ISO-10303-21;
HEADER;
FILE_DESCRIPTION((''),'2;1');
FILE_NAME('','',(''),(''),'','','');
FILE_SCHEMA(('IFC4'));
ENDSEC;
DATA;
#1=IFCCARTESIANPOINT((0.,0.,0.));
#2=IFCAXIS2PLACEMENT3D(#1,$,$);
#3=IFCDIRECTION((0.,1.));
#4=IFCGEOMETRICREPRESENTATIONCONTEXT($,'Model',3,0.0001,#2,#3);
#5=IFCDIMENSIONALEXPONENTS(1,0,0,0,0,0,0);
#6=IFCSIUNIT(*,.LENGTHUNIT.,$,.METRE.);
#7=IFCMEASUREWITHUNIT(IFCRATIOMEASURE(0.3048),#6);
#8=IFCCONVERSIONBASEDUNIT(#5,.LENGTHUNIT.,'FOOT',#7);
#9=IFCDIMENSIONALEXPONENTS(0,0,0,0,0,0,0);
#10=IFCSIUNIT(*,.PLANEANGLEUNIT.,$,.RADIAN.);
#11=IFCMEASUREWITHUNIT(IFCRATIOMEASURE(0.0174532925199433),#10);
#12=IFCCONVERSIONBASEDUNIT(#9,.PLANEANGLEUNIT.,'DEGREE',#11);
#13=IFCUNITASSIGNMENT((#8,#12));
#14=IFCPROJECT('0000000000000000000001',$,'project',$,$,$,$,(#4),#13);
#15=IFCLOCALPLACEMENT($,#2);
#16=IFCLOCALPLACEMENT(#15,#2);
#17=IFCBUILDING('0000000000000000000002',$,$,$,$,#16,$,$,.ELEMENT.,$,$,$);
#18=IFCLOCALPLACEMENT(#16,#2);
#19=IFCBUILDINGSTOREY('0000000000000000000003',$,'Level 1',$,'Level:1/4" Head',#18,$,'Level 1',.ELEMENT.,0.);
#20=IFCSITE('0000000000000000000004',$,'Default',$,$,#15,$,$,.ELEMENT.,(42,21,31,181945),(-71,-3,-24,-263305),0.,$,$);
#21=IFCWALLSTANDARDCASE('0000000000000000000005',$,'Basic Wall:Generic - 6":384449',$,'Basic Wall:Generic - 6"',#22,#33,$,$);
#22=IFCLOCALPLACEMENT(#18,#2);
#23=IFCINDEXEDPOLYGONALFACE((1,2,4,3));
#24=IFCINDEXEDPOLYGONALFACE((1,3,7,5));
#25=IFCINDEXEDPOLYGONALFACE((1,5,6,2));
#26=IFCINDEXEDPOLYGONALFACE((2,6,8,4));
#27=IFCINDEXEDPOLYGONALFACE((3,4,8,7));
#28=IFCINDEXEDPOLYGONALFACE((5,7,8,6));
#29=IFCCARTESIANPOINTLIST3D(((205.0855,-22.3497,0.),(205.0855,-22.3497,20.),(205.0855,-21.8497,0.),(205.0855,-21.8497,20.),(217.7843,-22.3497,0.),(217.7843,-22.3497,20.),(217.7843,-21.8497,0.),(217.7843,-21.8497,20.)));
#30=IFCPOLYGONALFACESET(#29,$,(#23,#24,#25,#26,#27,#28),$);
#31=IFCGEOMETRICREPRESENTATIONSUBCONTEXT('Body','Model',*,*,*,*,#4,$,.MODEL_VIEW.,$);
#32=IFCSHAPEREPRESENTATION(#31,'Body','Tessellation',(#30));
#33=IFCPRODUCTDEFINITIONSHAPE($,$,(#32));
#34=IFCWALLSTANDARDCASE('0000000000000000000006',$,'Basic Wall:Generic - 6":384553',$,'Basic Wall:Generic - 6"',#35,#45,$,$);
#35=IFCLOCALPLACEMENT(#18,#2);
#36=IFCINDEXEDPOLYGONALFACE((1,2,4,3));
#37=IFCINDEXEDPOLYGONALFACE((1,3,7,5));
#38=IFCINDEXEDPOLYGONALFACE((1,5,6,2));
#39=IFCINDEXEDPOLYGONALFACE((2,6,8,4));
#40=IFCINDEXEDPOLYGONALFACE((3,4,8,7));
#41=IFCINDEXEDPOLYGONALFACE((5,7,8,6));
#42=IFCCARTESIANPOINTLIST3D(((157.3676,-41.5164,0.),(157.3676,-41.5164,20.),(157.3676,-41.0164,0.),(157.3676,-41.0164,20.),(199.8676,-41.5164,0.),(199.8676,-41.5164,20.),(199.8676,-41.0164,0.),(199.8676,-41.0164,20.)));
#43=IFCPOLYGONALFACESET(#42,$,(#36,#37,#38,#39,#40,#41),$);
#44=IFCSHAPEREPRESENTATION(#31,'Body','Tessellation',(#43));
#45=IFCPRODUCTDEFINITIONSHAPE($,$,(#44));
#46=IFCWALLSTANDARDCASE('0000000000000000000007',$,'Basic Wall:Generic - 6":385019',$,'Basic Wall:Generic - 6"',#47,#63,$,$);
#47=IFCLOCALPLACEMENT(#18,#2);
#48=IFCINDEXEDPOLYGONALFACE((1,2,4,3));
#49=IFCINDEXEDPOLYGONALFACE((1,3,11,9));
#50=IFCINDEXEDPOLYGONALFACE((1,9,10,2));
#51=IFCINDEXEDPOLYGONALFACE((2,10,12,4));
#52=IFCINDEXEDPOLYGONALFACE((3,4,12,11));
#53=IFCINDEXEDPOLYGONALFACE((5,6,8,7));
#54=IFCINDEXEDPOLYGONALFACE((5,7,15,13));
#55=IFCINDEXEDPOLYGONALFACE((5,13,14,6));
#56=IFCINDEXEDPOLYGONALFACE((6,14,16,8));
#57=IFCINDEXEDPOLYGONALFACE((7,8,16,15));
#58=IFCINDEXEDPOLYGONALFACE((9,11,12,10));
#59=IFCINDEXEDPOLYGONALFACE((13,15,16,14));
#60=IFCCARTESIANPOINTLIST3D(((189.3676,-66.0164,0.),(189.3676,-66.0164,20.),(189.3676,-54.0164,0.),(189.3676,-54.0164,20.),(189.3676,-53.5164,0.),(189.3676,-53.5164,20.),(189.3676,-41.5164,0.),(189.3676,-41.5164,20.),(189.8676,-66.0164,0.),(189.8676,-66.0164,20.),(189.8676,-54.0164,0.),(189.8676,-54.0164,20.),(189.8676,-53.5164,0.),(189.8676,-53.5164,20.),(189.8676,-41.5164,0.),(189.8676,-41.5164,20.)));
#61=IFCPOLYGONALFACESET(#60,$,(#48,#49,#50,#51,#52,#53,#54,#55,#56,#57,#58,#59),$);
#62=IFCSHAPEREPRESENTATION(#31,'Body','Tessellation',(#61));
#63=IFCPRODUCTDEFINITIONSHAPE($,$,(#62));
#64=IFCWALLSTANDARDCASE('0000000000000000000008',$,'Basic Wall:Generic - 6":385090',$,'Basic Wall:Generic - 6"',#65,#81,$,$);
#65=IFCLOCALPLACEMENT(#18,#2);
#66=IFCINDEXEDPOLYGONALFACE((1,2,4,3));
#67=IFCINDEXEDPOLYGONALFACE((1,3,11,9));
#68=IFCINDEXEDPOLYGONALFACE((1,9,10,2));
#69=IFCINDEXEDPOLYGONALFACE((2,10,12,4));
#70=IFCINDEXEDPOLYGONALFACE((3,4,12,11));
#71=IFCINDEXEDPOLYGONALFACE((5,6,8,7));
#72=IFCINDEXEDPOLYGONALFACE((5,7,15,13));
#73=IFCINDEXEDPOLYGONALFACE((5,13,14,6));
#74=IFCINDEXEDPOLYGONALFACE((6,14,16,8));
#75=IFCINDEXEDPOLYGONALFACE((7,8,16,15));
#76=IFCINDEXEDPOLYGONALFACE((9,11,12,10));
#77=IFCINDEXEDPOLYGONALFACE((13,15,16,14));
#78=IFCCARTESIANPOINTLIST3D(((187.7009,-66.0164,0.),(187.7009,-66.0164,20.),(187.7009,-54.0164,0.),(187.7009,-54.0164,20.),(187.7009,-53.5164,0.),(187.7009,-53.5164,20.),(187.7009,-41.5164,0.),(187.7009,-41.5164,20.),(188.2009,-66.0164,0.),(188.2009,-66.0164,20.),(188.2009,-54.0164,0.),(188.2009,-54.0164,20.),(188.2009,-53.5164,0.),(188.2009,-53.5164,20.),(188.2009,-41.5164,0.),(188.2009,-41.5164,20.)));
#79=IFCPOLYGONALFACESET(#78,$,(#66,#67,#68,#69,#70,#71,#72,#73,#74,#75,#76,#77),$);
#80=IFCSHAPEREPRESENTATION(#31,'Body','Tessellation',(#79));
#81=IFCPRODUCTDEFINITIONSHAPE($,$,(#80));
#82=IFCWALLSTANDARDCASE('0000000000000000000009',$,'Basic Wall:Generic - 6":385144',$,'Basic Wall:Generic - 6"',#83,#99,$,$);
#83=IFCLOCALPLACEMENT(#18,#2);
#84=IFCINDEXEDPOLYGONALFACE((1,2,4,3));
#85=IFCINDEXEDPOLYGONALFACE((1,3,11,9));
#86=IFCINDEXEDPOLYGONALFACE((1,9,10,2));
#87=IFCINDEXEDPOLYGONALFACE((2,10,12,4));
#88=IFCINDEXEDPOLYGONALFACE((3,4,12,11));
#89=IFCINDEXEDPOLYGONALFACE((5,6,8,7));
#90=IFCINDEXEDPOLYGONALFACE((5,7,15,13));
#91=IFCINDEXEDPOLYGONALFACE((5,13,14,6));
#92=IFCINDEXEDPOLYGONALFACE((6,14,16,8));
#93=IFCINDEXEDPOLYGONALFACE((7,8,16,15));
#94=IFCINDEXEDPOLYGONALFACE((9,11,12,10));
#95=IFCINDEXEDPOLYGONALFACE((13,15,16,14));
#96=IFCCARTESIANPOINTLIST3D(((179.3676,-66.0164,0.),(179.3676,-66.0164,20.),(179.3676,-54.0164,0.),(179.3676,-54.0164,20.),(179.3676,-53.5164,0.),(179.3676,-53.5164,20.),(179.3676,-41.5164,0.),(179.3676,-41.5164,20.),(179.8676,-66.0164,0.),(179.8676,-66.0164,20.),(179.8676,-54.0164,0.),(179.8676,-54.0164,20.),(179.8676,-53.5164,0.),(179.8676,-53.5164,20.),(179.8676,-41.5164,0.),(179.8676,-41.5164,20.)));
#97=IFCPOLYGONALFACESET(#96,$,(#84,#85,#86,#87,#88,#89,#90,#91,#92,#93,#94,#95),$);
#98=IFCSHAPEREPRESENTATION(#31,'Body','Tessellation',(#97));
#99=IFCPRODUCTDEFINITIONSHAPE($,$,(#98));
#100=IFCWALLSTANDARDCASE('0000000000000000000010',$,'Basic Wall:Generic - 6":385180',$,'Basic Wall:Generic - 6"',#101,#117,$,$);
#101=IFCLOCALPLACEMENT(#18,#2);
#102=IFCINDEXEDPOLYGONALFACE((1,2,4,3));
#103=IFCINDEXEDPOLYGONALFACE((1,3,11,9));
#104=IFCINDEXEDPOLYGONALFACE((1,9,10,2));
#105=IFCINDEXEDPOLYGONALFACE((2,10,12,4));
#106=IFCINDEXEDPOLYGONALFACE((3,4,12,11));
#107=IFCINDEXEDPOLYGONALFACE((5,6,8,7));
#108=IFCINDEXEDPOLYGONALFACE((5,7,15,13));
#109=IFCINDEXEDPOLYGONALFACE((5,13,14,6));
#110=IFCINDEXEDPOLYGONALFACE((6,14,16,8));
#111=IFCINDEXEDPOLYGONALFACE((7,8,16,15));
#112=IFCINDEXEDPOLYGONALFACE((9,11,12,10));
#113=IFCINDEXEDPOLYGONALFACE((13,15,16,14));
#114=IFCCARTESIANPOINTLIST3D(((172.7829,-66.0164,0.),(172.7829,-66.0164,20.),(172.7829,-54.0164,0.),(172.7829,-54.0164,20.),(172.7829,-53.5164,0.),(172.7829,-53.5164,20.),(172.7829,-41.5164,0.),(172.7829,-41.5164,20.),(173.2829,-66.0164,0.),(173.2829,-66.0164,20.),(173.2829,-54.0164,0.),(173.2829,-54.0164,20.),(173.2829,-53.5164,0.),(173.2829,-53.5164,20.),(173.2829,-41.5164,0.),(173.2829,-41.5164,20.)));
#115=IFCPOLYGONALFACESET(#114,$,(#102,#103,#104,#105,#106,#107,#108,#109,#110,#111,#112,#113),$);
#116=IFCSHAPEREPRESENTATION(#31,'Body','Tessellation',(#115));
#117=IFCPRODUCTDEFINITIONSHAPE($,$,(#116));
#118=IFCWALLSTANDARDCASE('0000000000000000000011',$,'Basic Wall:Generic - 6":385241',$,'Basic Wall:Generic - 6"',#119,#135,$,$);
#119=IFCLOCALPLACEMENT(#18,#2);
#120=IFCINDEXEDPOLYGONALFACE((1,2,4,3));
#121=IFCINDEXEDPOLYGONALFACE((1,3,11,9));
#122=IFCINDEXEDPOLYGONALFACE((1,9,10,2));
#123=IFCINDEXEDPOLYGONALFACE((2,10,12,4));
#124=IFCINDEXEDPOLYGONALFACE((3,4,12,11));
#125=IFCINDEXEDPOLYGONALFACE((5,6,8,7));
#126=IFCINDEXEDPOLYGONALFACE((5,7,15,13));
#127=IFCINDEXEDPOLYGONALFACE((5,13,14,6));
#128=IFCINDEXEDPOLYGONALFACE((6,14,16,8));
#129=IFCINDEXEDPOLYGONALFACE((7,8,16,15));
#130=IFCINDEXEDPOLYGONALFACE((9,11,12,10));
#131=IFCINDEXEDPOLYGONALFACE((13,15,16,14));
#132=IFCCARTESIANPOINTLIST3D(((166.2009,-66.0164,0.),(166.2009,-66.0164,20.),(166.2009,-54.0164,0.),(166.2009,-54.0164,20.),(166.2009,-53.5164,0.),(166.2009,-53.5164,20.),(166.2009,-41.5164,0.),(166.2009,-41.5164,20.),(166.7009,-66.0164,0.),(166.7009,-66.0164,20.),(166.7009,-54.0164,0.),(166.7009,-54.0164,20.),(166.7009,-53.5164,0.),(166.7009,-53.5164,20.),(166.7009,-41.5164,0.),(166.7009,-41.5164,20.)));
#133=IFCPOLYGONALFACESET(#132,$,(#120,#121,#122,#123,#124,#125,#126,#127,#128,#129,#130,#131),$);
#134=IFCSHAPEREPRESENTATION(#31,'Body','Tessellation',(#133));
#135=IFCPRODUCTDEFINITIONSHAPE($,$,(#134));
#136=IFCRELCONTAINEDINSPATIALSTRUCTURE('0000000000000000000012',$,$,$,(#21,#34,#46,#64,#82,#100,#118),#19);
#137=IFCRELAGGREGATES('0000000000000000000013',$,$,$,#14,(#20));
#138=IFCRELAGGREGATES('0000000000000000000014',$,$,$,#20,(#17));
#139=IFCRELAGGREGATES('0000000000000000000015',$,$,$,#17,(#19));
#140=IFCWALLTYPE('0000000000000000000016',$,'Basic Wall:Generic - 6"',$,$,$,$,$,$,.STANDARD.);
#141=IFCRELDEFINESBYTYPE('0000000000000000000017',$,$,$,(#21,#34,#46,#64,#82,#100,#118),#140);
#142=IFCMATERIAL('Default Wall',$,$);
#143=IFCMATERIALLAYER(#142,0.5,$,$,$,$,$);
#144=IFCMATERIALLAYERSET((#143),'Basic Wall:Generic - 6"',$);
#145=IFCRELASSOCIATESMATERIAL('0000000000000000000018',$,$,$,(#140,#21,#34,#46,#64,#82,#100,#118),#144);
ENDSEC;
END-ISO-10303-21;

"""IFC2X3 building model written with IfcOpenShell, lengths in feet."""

from ifc_helpers import new_model, entity, si_unit, converted_unit, direction, frame, frame_2d, origin, origin_2d_with_axis, place, context, subcontext, project, spatial, rectangle, extrude, material, layer, layer_set, layer_usage, type_object, element, save


model = new_model("IFC2X3")

# Units and contexts
model_context = context("Model", 3, precision=0.0001, world=origin(), true_north=direction((0.0, 1.0)))
body_context = subcontext(model_context, "Body", "Model", "MODEL_VIEW")
ifc_project = project(units=[converted_unit("LENGTHUNIT", "FOOT", entity("IfcRatioMeasure", 0.3048), si_unit("LENGTHUNIT", "METRE"), dimensions=[1, 0, 0, 0, 0, 0, 0]), converted_unit("PLANEANGLEUNIT", "DEGREE", entity("IfcRatioMeasure", 0.0174532925199433), si_unit("PLANEANGLEUNIT", "RADIAN"), dimensions=[0, 0, 0, 0, 0, 0, 0])], contexts=[model_context])

# Site, building, storey
site_placement = place(None, origin())
site = spatial("IfcSite", under=ifc_project, at=site_placement, Name="Default", CompositionType="ELEMENT", RefLatitude=(42, 21, 31, 181945), RefLongitude=(-71, -3, -24, -263305), RefElevation=0.0)
building_placement = place(site_placement, origin())
building = spatial("IfcBuilding", under=site, at=building_placement, CompositionType="ELEMENT")
storey_placement = place(building_placement, origin())
storey = spatial("IfcBuildingStorey", under=building, at=storey_placement, Name="Level 1", ObjectType="Level:1/4\" Head", LongName="Level 1", CompositionType="ELEMENT", Elevation=0.0)

# Walls
ifc_material = material(Name="Default Wall")
ifc_layer = layer(ifc_material, 0.5)
ifc_layer_set = layer_set([ifc_layer], Name="Basic Wall:Generic - 6\"")
wall_type = type_object("IfcWallType", Name="Basic Wall:Generic - 6\"", PredefinedType="STANDARD", material=ifc_layer_set)
ifc_layer_usage_1 = layer_usage(ifc_layer_set, "AXIS2", "NEGATIVE", 0.25)
wall_1_placement = place(storey_placement, frame((205.0855, -22.0997, 0.0)))
element("IfcWallStandardCase", 1, at=wall_1_placement, inside=storey, type_object=wall_type, material=ifc_layer_usage_1, Name="Basic Wall:Generic - 6\":384449", ObjectType="Basic Wall:Generic - 6\"", context=body_context, shape_type="SweptSolid", body=[
    extrude(rectangle(XDim=12.6987, YDim=0.5, at=frame_2d((6.3494, 0.0), x_axis=(-1.0, 0.0))), origin(), (0.0, 0.0, 1.0), 20.0),
])
ifc_layer_usage_2 = layer_usage(ifc_layer_set, "AXIS2", "NEGATIVE", 0.25)
wall_2_placement = place(storey_placement, frame((199.8676, -41.2664, 0.0), z_axis=(0.0, 0.0, 1.0), x_axis=(-1.0, 0.0, 0.0)))
element("IfcWallStandardCase", 2, at=wall_2_placement, inside=storey, type_object=wall_type, material=ifc_layer_usage_2, Name="Basic Wall:Generic - 6\":384553", ObjectType="Basic Wall:Generic - 6\"", context=body_context, shape_type="SweptSolid", body=[
    extrude(rectangle(XDim=42.5, YDim=0.5, at=frame_2d((21.25, 0.0), x_axis=(-1.0, 0.0))), origin(), (0.0, 0.0, 1.0), 20.0),
])

# Walls, openings
ifc_layer_usage_3 = layer_usage(ifc_layer_set, "AXIS2", "NEGATIVE", 0.25)
wall_3_placement = place(storey_placement, frame((189.6176, -41.5164, 0.0), z_axis=(0.0, 0.0, 1.0), x_axis=(0.0, -1.0, 0.0)))
wall_3 = element("IfcWallStandardCase", 3, at=wall_3_placement, inside=storey, type_object=wall_type, material=ifc_layer_usage_3, Name="Basic Wall:Generic - 6\":385019", ObjectType="Basic Wall:Generic - 6\"", context=body_context, shape_type="SweptSolid", body=[
    extrude(rectangle(XDim=24.5, YDim=0.5, at=frame_2d((12.25, 0.0), x_axis=(-1.0, 0.0))), origin(), (0.0, 0.0, 1.0), 20.0),
])
opening_1_placement = place(storey_placement, frame((189.6176, -41.5164, 0.0), z_axis=(0.0, 0.0, 1.0), x_axis=(0.0, -1.0, 0.0)))
element("IfcOpeningElement", 4, at=opening_1_placement, cuts=wall_3, ObjectType="Opening", context=body_context, shape_type="SweptSolid", body=[
    extrude(rectangle(XDim=20.0, YDim=0.5, at=origin_2d_with_axis()), frame((12.5, 0.0, 10.0), z_axis=(-1.0, 0.0, 0.0), x_axis=(0.0, 0.0, 1.0)), (0.0, 0.0, 1.0), 0.5),
])
ifc_layer_usage_4 = layer_usage(ifc_layer_set, "AXIS2", "NEGATIVE", 0.25)
wall_4_placement = place(storey_placement, frame((187.9509, -66.0164, 0.0), z_axis=(0.0, 0.0, 1.0), x_axis=(0.0, 1.0, 0.0)))
wall_4 = element("IfcWallStandardCase", 5, at=wall_4_placement, inside=storey, type_object=wall_type, material=ifc_layer_usage_4, Name="Basic Wall:Generic - 6\":385090", ObjectType="Basic Wall:Generic - 6\"", context=body_context, shape_type="SweptSolid", body=[
    extrude(rectangle(XDim=24.5, YDim=0.5, at=frame_2d((12.25, 0.0), x_axis=(-1.0, 0.0))), origin(), (0.0, 0.0, 1.0), 20.0),
])
opening_2_placement = place(storey_placement, frame((187.9509, -66.0164, 0.0), z_axis=(0.0, 0.0, 1.0), x_axis=(0.0, 1.0, 0.0)))
element("IfcOpeningElement", 6, at=opening_2_placement, cuts=wall_4, ObjectType="Opening", context=body_context, shape_type="SweptSolid", body=[
    extrude(rectangle(XDim=20.0, YDim=0.5, at=origin_2d_with_axis()), frame((12.0, 0.0, 10.0), z_axis=(1.0, 0.0, 0.0), x_axis=(0.0, 0.0, -1.0)), (0.0, 0.0, 1.0), 0.5),
])
ifc_layer_usage_5 = layer_usage(ifc_layer_set, "AXIS2", "NEGATIVE", 0.25)
wall_5_placement = place(storey_placement, frame((179.6176, -41.5164, 0.0), z_axis=(0.0, 0.0, 1.0), x_axis=(0.0, -1.0, 0.0)))
wall_5 = element("IfcWallStandardCase", 7, at=wall_5_placement, inside=storey, type_object=wall_type, material=ifc_layer_usage_5, Name="Basic Wall:Generic - 6\":385144", ObjectType="Basic Wall:Generic - 6\"", context=body_context, shape_type="SweptSolid", body=[
    extrude(rectangle(XDim=24.5, YDim=0.5, at=frame_2d((12.25, 0.0), x_axis=(-1.0, 0.0))), origin(), (0.0, 0.0, 1.0), 20.0),
])
opening_3_placement = place(storey_placement, frame((179.6176, -41.5164, 0.0), z_axis=(0.0, 0.0, 1.0), x_axis=(0.0, -1.0, 0.0)))
element("IfcOpeningElement", 8, at=opening_3_placement, cuts=wall_5, ObjectType="Opening", context=body_context, shape_type="SweptSolid", body=[
    extrude(rectangle(XDim=20.0, YDim=0.5, at=origin_2d_with_axis()), frame((12.5, 0.0, 10.0), z_axis=(-1.0, 0.0, 0.0), x_axis=(0.0, 0.0, 1.0)), (0.0, 0.0, 1.0), 0.5),
])
ifc_layer_usage_6 = layer_usage(ifc_layer_set, "AXIS2", "NEGATIVE", 0.25)
wall_6_placement = place(storey_placement, frame((173.0329, -66.0164, 0.0), z_axis=(0.0, 0.0, 1.0), x_axis=(0.0, 1.0, 0.0)))
wall_6 = element("IfcWallStandardCase", 9, at=wall_6_placement, inside=storey, type_object=wall_type, material=ifc_layer_usage_6, Name="Basic Wall:Generic - 6\":385180", ObjectType="Basic Wall:Generic - 6\"", context=body_context, shape_type="SweptSolid", body=[
    extrude(rectangle(XDim=24.5, YDim=0.5, at=frame_2d((12.25, 0.0), x_axis=(-1.0, 0.0))), origin(), (0.0, 0.0, 1.0), 20.0),
])
opening_4_placement = place(storey_placement, frame((173.0329, -66.0164, 0.0), z_axis=(0.0, 0.0, 1.0), x_axis=(0.0, 1.0, 0.0)))
element("IfcOpeningElement", 10, at=opening_4_placement, cuts=wall_6, ObjectType="Opening", context=body_context, shape_type="SweptSolid", body=[
    extrude(rectangle(XDim=20.0, YDim=0.5, at=origin_2d_with_axis()), frame((12.0, 0.0, 10.0), z_axis=(1.0, 0.0, 0.0), x_axis=(0.0, 0.0, -1.0)), (0.0, 0.0, 1.0), 0.5),
])
ifc_layer_usage_7 = layer_usage(ifc_layer_set, "AXIS2", "NEGATIVE", 0.25)
wall_7_placement = place(storey_placement, frame((166.4509, -41.5164, 0.0), z_axis=(0.0, 0.0, 1.0), x_axis=(0.0, -1.0, 0.0)))
wall_7 = element("IfcWallStandardCase", 11, at=wall_7_placement, inside=storey, type_object=wall_type, material=ifc_layer_usage_7, Name="Basic Wall:Generic - 6\":385241", ObjectType="Basic Wall:Generic - 6\"", context=body_context, shape_type="SweptSolid", body=[
    extrude(rectangle(XDim=24.5, YDim=0.5, at=frame_2d((12.25, 0.0), x_axis=(-1.0, 0.0))), origin(), (0.0, 0.0, 1.0), 20.0),
])
opening_5_placement = place(storey_placement, frame((166.4509, -41.5164, 0.0), z_axis=(0.0, 0.0, 1.0), x_axis=(0.0, -1.0, 0.0)))
element("IfcOpeningElement", 12, at=opening_5_placement, cuts=wall_7, ObjectType="Opening", context=body_context, shape_type="SweptSolid", body=[
    extrude(rectangle(XDim=20.0, YDim=0.5, at=origin_2d_with_axis()), frame((12.5, 0.0, 10.0), z_axis=(-1.0, 0.0, 0.0), x_axis=(0.0, 0.0, 1.0)), (0.0, 0.0, 1.0), 0.5),
])

save(model, "model.ifc")
